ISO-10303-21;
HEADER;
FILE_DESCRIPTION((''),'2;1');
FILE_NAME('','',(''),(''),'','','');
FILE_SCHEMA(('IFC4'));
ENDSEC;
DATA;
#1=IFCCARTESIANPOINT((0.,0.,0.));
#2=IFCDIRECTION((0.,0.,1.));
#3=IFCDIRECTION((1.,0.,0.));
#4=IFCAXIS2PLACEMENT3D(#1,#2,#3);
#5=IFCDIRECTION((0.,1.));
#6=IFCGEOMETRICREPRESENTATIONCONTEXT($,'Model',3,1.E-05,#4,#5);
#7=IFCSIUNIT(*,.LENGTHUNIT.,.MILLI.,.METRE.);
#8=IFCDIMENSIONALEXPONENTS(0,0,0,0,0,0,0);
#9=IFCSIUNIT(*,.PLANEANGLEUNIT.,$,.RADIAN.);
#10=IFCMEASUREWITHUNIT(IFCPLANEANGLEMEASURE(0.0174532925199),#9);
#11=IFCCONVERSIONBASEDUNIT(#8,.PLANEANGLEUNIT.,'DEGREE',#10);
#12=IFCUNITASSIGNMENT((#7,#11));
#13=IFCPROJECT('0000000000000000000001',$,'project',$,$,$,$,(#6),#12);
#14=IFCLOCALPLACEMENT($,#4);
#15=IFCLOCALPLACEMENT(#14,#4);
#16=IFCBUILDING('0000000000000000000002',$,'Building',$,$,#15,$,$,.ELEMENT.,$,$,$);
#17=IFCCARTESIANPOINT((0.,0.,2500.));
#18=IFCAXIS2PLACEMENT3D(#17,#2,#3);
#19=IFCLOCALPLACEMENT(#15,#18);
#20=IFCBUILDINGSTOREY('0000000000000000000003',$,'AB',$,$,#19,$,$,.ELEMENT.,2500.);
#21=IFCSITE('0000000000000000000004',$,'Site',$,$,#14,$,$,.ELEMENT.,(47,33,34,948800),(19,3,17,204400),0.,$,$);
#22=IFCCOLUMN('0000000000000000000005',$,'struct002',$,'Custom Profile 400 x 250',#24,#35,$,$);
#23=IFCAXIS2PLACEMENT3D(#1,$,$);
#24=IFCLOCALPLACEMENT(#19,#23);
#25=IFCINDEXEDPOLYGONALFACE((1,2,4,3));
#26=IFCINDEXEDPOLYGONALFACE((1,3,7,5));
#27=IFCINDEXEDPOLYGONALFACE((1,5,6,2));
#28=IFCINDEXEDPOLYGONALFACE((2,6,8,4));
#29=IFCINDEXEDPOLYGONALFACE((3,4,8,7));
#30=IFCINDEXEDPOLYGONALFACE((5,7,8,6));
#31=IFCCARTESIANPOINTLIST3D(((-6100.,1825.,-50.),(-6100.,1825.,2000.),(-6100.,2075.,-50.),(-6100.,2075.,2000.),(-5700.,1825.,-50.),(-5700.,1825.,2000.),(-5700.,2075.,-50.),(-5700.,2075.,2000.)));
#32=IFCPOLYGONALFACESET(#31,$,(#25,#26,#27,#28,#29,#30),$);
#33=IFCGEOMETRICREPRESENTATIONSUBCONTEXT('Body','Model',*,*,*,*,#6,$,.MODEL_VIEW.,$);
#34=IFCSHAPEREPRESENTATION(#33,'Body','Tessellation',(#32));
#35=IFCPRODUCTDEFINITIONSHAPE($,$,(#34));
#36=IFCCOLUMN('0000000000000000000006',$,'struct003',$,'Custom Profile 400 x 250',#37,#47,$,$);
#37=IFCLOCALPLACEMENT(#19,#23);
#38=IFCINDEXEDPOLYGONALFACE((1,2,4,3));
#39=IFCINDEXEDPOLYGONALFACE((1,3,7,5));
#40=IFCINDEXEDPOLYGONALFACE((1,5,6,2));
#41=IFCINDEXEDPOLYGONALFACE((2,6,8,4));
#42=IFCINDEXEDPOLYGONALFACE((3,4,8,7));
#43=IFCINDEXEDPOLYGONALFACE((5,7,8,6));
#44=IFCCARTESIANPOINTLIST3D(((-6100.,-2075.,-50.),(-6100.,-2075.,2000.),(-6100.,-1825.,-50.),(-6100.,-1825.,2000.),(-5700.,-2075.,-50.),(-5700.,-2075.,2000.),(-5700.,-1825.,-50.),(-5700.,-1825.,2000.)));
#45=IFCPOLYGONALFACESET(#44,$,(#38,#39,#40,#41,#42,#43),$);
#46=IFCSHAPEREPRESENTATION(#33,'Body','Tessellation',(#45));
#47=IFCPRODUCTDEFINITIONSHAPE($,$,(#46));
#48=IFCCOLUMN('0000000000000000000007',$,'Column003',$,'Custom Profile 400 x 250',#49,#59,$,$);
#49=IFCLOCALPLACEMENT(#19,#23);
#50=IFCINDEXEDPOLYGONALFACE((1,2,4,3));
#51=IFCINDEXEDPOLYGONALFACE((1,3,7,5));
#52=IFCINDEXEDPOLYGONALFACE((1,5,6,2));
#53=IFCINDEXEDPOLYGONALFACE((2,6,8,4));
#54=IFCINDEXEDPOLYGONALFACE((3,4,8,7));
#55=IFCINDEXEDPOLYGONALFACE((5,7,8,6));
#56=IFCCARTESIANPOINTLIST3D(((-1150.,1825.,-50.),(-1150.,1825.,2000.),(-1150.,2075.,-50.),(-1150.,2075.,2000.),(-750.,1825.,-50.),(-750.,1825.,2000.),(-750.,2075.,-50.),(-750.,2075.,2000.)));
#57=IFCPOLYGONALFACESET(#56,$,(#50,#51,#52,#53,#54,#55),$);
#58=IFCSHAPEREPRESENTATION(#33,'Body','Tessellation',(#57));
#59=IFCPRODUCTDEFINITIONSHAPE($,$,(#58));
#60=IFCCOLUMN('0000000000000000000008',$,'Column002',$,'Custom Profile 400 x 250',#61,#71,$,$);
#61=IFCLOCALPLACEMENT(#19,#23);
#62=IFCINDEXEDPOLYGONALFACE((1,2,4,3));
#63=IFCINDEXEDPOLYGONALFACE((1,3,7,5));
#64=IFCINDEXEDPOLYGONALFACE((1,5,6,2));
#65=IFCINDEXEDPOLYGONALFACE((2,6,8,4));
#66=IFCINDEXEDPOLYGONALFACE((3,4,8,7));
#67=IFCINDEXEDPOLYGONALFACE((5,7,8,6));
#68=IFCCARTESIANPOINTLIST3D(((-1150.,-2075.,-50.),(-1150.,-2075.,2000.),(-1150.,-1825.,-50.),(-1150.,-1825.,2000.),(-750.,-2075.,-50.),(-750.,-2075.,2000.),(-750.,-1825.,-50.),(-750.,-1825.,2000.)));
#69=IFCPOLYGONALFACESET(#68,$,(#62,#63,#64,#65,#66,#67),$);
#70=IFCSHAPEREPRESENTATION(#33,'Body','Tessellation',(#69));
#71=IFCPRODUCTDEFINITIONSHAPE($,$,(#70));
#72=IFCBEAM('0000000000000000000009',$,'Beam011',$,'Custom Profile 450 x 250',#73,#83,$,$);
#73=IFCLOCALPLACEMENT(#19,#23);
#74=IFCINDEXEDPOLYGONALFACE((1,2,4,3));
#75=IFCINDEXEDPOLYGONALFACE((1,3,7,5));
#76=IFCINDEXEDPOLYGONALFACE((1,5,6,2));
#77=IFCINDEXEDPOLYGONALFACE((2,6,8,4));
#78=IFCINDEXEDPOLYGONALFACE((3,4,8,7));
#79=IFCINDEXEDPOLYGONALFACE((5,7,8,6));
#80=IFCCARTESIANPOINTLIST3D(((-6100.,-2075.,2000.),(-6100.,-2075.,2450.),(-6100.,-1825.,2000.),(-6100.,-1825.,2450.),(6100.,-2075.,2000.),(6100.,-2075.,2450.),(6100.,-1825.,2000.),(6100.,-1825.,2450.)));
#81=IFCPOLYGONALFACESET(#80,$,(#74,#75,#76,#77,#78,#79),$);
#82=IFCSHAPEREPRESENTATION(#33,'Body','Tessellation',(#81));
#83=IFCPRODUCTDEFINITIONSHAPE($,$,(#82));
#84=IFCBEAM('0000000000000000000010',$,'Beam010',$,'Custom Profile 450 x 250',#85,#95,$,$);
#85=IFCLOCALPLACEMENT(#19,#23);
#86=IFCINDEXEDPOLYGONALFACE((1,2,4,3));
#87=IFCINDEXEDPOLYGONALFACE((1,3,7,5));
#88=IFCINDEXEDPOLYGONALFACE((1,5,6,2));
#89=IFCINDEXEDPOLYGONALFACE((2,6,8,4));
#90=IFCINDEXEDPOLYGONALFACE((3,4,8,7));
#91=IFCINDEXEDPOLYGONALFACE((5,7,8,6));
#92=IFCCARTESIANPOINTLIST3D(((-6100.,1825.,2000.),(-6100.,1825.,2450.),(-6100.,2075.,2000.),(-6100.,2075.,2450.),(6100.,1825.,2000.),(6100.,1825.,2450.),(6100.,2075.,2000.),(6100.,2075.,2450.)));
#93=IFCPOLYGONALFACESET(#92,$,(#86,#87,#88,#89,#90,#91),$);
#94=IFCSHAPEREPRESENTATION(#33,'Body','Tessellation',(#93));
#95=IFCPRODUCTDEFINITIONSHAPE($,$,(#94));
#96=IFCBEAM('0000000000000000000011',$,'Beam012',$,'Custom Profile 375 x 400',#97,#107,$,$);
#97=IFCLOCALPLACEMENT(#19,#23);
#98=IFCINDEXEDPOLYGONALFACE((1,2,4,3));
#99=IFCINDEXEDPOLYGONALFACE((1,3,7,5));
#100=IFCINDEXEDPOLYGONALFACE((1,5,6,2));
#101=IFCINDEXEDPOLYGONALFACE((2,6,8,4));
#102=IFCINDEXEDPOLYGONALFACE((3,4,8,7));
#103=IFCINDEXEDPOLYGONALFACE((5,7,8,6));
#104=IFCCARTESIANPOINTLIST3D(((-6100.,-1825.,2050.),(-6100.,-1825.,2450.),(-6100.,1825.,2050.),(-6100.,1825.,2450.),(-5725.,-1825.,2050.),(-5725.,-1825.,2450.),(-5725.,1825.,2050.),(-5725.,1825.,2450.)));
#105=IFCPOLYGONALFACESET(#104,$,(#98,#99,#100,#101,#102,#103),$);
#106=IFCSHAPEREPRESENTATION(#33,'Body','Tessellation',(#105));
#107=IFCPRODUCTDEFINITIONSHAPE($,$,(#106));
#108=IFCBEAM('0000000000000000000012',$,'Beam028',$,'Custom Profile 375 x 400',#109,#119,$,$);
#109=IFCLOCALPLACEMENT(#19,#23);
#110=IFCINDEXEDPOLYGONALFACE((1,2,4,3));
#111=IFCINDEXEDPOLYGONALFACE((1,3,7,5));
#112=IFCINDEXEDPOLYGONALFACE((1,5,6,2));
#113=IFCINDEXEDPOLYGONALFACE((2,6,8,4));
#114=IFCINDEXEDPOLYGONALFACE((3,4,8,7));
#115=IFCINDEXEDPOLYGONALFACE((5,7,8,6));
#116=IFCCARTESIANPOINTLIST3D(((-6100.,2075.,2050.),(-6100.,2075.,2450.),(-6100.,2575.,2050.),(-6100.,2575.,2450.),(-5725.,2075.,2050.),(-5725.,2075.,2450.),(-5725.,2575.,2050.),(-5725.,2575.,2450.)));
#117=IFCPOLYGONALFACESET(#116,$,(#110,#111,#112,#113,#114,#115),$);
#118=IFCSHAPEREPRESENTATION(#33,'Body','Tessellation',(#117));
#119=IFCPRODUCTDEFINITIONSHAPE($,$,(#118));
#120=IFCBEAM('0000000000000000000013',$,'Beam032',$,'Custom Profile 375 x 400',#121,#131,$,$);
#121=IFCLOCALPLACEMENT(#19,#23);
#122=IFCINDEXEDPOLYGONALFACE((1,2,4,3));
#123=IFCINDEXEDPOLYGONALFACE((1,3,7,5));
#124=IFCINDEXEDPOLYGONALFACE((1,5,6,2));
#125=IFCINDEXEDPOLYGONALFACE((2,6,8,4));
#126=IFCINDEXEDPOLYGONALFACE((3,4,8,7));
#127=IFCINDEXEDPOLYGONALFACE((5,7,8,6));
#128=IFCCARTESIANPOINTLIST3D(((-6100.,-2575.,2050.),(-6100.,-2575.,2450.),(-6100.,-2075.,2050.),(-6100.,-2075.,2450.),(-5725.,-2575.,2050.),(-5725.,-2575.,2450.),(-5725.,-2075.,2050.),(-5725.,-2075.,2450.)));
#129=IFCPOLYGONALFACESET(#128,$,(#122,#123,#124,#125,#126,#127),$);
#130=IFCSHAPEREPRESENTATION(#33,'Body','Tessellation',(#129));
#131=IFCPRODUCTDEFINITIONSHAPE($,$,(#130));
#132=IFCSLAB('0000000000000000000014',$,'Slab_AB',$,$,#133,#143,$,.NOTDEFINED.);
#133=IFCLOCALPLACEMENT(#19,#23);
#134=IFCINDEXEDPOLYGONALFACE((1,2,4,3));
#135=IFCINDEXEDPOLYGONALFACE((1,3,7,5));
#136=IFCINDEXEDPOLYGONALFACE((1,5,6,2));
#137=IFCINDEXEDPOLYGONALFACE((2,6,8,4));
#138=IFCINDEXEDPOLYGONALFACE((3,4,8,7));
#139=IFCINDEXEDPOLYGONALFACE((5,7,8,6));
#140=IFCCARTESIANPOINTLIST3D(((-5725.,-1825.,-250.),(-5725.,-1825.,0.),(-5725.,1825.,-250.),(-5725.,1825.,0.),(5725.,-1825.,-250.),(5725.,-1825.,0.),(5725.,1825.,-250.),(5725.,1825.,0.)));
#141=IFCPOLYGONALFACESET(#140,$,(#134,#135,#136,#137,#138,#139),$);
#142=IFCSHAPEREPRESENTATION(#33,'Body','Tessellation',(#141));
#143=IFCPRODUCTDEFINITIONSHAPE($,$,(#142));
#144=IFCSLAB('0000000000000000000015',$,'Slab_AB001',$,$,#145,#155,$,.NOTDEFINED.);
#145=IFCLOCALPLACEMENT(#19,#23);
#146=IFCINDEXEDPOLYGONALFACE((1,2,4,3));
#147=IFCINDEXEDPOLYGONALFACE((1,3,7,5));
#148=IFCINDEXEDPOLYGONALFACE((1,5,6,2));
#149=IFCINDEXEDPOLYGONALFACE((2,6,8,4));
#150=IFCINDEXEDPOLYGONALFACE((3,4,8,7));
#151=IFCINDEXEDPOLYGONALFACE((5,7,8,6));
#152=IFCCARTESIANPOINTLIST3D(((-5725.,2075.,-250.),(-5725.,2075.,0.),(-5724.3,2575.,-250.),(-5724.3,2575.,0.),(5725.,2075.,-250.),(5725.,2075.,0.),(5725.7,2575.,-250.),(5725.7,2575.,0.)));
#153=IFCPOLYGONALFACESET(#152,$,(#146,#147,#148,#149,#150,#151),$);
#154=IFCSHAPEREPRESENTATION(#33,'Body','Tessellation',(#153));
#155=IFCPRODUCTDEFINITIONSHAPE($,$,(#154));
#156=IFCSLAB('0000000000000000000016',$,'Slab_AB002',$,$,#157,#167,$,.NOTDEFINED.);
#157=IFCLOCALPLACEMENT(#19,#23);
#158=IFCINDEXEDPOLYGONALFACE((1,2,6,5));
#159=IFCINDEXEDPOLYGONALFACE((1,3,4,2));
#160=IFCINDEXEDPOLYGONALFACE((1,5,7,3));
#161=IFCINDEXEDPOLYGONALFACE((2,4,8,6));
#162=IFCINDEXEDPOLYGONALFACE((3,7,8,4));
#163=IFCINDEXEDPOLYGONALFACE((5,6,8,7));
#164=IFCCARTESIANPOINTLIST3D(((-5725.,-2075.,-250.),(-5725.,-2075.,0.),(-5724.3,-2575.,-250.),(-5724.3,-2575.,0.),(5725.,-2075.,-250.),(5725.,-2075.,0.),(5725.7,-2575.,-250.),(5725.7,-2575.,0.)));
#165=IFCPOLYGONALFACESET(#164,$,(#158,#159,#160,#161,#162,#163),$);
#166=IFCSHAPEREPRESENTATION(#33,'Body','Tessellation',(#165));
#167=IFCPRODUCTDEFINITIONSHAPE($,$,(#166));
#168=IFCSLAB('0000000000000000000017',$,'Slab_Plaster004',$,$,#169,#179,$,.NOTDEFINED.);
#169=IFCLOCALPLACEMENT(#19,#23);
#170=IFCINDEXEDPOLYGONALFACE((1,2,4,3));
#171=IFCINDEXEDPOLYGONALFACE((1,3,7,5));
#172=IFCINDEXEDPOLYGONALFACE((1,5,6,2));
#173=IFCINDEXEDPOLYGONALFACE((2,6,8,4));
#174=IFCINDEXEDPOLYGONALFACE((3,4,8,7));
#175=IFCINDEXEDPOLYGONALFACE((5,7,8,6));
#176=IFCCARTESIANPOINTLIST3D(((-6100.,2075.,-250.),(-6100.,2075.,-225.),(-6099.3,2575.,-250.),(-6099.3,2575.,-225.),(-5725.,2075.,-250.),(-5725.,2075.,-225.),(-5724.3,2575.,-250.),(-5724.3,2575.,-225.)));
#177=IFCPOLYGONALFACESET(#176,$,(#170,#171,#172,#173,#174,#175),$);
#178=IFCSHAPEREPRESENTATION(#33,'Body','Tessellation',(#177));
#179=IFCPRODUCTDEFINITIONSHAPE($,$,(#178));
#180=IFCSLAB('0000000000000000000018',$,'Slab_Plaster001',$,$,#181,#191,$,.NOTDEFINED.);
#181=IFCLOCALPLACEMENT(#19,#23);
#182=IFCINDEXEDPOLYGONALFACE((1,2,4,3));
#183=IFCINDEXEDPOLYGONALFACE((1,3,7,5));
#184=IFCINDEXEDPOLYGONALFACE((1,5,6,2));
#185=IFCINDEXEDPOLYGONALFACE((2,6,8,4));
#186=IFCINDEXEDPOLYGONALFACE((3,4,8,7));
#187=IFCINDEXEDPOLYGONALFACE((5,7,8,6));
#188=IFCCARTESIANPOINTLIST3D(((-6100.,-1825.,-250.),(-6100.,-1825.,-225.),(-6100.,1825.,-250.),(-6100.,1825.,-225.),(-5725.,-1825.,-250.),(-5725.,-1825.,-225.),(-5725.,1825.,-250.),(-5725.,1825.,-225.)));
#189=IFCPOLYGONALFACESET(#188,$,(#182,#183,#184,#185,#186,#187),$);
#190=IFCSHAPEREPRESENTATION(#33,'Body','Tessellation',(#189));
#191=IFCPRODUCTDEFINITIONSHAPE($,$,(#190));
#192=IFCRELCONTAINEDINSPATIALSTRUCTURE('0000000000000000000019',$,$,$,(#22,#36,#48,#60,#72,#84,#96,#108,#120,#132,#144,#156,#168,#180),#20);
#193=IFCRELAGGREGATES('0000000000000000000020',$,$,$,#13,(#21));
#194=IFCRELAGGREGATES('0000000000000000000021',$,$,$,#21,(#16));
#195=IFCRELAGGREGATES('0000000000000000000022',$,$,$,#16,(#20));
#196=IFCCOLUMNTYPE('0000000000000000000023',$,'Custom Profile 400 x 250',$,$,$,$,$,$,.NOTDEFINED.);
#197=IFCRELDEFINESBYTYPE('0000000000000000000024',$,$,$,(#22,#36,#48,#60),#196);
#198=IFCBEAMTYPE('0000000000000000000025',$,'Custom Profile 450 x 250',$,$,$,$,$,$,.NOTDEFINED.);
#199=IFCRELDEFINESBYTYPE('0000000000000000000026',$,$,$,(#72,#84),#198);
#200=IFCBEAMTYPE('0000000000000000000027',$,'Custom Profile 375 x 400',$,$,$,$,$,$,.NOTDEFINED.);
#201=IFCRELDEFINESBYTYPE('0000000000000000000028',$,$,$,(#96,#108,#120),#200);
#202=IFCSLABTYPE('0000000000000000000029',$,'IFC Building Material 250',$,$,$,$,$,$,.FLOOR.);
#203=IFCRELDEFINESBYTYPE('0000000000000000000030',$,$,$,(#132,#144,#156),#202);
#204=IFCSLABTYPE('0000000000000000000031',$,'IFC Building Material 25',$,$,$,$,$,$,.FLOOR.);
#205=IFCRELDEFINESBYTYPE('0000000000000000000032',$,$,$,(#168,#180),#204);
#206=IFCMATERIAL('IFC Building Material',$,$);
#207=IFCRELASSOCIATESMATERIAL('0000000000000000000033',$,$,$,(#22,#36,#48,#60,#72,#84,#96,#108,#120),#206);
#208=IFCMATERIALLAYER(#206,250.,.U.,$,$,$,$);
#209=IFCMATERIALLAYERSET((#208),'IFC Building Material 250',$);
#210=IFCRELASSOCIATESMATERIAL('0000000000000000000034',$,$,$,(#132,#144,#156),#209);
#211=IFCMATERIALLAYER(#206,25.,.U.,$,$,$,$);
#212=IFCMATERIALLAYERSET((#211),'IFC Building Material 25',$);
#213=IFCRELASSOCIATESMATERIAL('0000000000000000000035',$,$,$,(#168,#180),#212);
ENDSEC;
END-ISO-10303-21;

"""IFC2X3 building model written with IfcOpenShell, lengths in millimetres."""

from ifc_helpers import new_model, entity, si_unit, converted_unit, direction, frame, origin_with_axes, place, context, subcontext, project, spatial, polyline, outline, extrude, material, layer, layer_set, layer_usage, type_object, element, save


model = new_model("IFC2X3")

# Units and contexts
model_context = context("Model", 3, precision=1e-05, world=origin_with_axes(), true_north=direction((0.0, 1.0)))
body_context = subcontext(model_context, "Body", "Model", "MODEL_VIEW")
ifc_project = project(units=[si_unit("LENGTHUNIT", "METRE", prefix="MILLI"), converted_unit("PLANEANGLEUNIT", "DEGREE", entity("IfcPlaneAngleMeasure", 0.0174532925199), si_unit("PLANEANGLEUNIT", "RADIAN"), dimensions=[0, 0, 0, 0, 0, 0, 0])], contexts=[model_context])

# Site, building, storey
site_placement = place(None, origin_with_axes())
site = spatial("IfcSite", under=ifc_project, at=site_placement, Name="Site", CompositionType="ELEMENT", RefLatitude=(47, 33, 34, 948800), RefLongitude=(19, 3, 17, 204400), RefElevation=0.0)
building_placement = place(site_placement, origin_with_axes())
building = spatial("IfcBuilding", under=site, at=building_placement, Name="Building", CompositionType="ELEMENT")
storey_placement = place(building_placement, frame((0.0, 0.0, 2500.0), z_axis=(0.0, 0.0, 1.0), x_axis=(1.0, 0.0, 0.0)))
storey = spatial("IfcBuildingStorey", under=building, at=storey_placement, Name="AB", CompositionType="ELEMENT", Elevation=2500.0)

# Columns
ifc_material = material(Name="IFC Building Material")
column_type = type_object("IfcColumnType", Name="Custom Profile 400 x 250", PredefinedType="NOTDEFINED")
for number, where, z_axis, x_axis, name in (
    (1, (-5900.0, 1950.0, -50.0), (0.0, 0.0, 1.0), (1.0, 0.0, 0.0), "struct002"),
    (2, (-5900.0, -1950.0, -50.0), (0.0, 0.0, 1.0), (1.0, 0.0, 0.0), "struct003"),
    (3, (-950.0, 1950.0, -50.0), (0.0, 0.0, 1.0), (1.0, 0.0, 0.0), "Column003"),
    (4, (-950.0, -1950.0, -50.0), (0.0, 0.0, 1.0), (1.0, 0.0, 0.0), "Column002"),
):
    element("IfcColumn", number, at=place(storey_placement, frame(where, z_axis=z_axis, x_axis=x_axis)), inside=storey, type_object=column_type, material=ifc_material, Name=name, ObjectType="Custom Profile 400 x 250", context=body_context, shape_type="SweptSolid", body=[
        extrude(outline(polyline([(-200.0, -125.0), (200.0, -125.0), (200.0, 125.0), (-200.0, 125.0), (-200.0, -125.0)])), origin_with_axes(), (0.0, 0.0, 1.0), 2050.0),
    ])

# Beams
beam_type_1 = type_object("IfcBeamType", Name="Custom Profile 450 x 250", PredefinedType="NOTDEFINED")
for number, where, z_axis, x_axis, name in (
    (5, (-6100.0, -1950.0, 2225.0), (0.0, 0.0, 1.0), (0.0, -1.0, 0.0), "Beam011"),
    (6, (-6100.0, 1950.0, 2225.0), (0.0, 0.0, 1.0), (0.0, -1.0, 0.0), "Beam010"),
):
    element("IfcBeam", number, at=place(storey_placement, frame(where, z_axis=z_axis, x_axis=x_axis)), inside=storey, type_object=beam_type_1, material=ifc_material, Name=name, ObjectType="Custom Profile 450 x 250", context=body_context, shape_type="SweptSolid", body=[
        extrude(outline(polyline([(-125.0, -225.0), (125.0, -225.0), (125.0, 225.0), (-125.0, 225.0), (-125.0, -225.0)])), frame((0.0, 12200.0, 0.0), z_axis=(0.0, -1.0, 0.0), x_axis=(1.0, 0.0, 0.0)), (0.0, 0.0, 1.0), 12200.0),
    ])
beam_type_2 = type_object("IfcBeamType", Name="Custom Profile 375 x 400", PredefinedType="NOTDEFINED")
beam_placement = place(storey_placement, frame((-5912.5, -1825.0, 2250.0), z_axis=(0.0, 0.0, 1.0), x_axis=(1.0, 0.0, 0.0)))
element("IfcBeam", 7, at=beam_placement, inside=storey, type_object=beam_type_2, material=ifc_material, Name="Beam012", ObjectType="Custom Profile 375 x 400", context=body_context, shape_type="SweptSolid", body=[
    extrude(outline(polyline([(-187.5, -200.0), (187.5, -200.0), (187.5, 200.0), (-187.5, 200.0), (-187.5, -200.0)])), frame((0.0, 3650.0, 0.0), z_axis=(0.0, -1.0, 0.0), x_axis=(1.0, 0.0, 0.0)), (0.0, 0.0, 1.0), 3650.0),
])
for number, where, z_axis, x_axis, name in (
    (8, (-5912.5, 2075.0, 2250.0), (0.0, 0.0, 1.0), (1.0, 0.0, 0.0), "Beam028"),
    (9, (-5912.5, -2575.0, 2250.0), (0.0, 0.0, 1.0), (1.0, 0.0, 0.0), "Beam032"),
):
    element("IfcBeam", number, at=place(storey_placement, frame(where, z_axis=z_axis, x_axis=x_axis)), inside=storey, type_object=beam_type_2, material=ifc_material, Name=name, ObjectType="Custom Profile 375 x 400", context=body_context, shape_type="SweptSolid", body=[
        extrude(outline(polyline([(-187.5, -200.0), (187.5, -200.0), (187.5, 200.0), (-187.5, 200.0), (-187.5, -200.0)])), frame((0.0, 500.0, 0.0), z_axis=(0.0, -1.0, 0.0), x_axis=(1.0, 0.0, 0.0)), (0.0, 0.0, 1.0), 500.0),
    ])

# Slabs
ifc_layer_1 = layer(ifc_material, 250.0, ventilated="UNKNOWN")
ifc_layer_set_1 = layer_set([ifc_layer_1], Name="IFC Building Material 250")
ifc_layer_usage_1 = layer_usage(ifc_layer_set_1, "AXIS3", "NEGATIVE", 250.0)
slab_type_1 = type_object("IfcSlabType", Name="IFC Building Material 250", PredefinedType="FLOOR")
slab_1_placement = place(storey_placement, frame((-5725.0, -1825.0, 0.0), z_axis=(0.0, 0.0, 1.0), x_axis=(1.0, 0.0, 0.0)))
element("IfcSlab", 10, at=slab_1_placement, inside=storey, type_object=slab_type_1, material=ifc_layer_usage_1, Name="Slab_AB", PredefinedType="NOTDEFINED", context=body_context, shape_type="SweptSolid", body=[
    extrude(outline(polyline([(0.0, 0.0), (11450.0, 0.0), (11450.0, 3650.0), (0.0, 3650.0), (0.0, 0.0)])), frame((0.0, 0.0, -250.0), z_axis=(0.0, 0.0, 1.0), x_axis=(1.0, 0.0, 0.0)), (0.0, 0.0, 1.0), 250.0),
])
ifc_layer_usage_2 = layer_usage(ifc_layer_set_1, "AXIS3", "NEGATIVE", 250.0)
slab_2_placement = place(storey_placement, frame((-5724.3, 2575.0, 0.0), z_axis=(0.0, 0.0, 1.0), x_axis=(1.0, 0.0, 0.0)))
element("IfcSlab", 11, at=slab_2_placement, inside=storey, type_object=slab_type_1, material=ifc_layer_usage_2, Name="Slab_AB001", PredefinedType="NOTDEFINED", context=body_context, shape_type="SweptSolid", body=[
    extrude(outline(polyline([(0.0, 0.0), (-0.7, -500.0), (11449.3, -500.0), (11450.0, 0.0), (0.0, 0.0)])), frame((0.0, 0.0, -250.0), z_axis=(0.0, 0.0, 1.0), x_axis=(1.0, 0.0, 0.0)), (0.0, 0.0, 1.0), 250.0),
])
ifc_layer_usage_3 = layer_usage(ifc_layer_set_1, "AXIS3", "NEGATIVE", 250.0)
slab_3_placement = place(storey_placement, frame((-5724.3, -2575.0, 0.0), z_axis=(0.0, 0.0, 1.0), x_axis=(1.0, 0.0, 0.0)))
element("IfcSlab", 12, at=slab_3_placement, inside=storey, type_object=slab_type_1, material=ifc_layer_usage_3, Name="Slab_AB002", PredefinedType="NOTDEFINED", context=body_context, shape_type="SweptSolid", body=[
    extrude(outline(polyline([(0.0, 0.0), (11450.0, 0.0), (11449.3, 500.0), (-0.7, 500.0), (0.0, 0.0)])), frame((0.0, 0.0, -250.0), z_axis=(0.0, 0.0, 1.0), x_axis=(1.0, 0.0, 0.0)), (0.0, 0.0, 1.0), 250.0),
])
ifc_layer_2 = layer(ifc_material, 25.0, ventilated="UNKNOWN")
ifc_layer_set_2 = layer_set([ifc_layer_2], Name="IFC Building Material 25")
ifc_layer_usage_4 = layer_usage(ifc_layer_set_2, "AXIS3", "NEGATIVE", 25.0)
slab_type_2 = type_object("IfcSlabType", Name="IFC Building Material 25", PredefinedType="FLOOR")
slab_4_placement = place(storey_placement, frame((-5725.0, 2075.0, -225.0), z_axis=(0.0, 0.0, 1.0), x_axis=(1.0, 0.0, 0.0)))
element("IfcSlab", 13, at=slab_4_placement, inside=storey, type_object=slab_type_2, material=ifc_layer_usage_4, Name="Slab_Plaster004", PredefinedType="NOTDEFINED", context=body_context, shape_type="SweptSolid", body=[
    extrude(outline(polyline([(0.0, 0.0), (0.7, 500.0), (-374.3, 500.0), (-375.0, 0.0), (0.0, 0.0)])), frame((0.0, 0.0, -25.0), z_axis=(0.0, 0.0, 1.0), x_axis=(1.0, 0.0, 0.0)), (0.0, 0.0, 1.0), 25.0),
])
ifc_layer_usage_5 = layer_usage(ifc_layer_set_2, "AXIS3", "NEGATIVE", 25.0)
slab_5_placement = place(storey_placement, frame((-5725.0, -1825.0, -225.0), z_axis=(0.0, 0.0, 1.0), x_axis=(1.0, 0.0, 0.0)))
element("IfcSlab", 14, at=slab_5_placement, inside=storey, type_object=slab_type_2, material=ifc_layer_usage_5, Name="Slab_Plaster001", PredefinedType="NOTDEFINED", context=body_context, shape_type="SweptSolid", body=[
    extrude(outline(polyline([(0.0, 0.0), (0.0, 3650.0), (-375.0, 3650.0), (-375.0, 0.0), (0.0, 0.0)])), frame((0.0, 0.0, -25.0), z_axis=(0.0, 0.0, 1.0), x_axis=(1.0, 0.0, 0.0)), (0.0, 0.0, 1.0), 25.0),
])

save(model, "model.ifc")
